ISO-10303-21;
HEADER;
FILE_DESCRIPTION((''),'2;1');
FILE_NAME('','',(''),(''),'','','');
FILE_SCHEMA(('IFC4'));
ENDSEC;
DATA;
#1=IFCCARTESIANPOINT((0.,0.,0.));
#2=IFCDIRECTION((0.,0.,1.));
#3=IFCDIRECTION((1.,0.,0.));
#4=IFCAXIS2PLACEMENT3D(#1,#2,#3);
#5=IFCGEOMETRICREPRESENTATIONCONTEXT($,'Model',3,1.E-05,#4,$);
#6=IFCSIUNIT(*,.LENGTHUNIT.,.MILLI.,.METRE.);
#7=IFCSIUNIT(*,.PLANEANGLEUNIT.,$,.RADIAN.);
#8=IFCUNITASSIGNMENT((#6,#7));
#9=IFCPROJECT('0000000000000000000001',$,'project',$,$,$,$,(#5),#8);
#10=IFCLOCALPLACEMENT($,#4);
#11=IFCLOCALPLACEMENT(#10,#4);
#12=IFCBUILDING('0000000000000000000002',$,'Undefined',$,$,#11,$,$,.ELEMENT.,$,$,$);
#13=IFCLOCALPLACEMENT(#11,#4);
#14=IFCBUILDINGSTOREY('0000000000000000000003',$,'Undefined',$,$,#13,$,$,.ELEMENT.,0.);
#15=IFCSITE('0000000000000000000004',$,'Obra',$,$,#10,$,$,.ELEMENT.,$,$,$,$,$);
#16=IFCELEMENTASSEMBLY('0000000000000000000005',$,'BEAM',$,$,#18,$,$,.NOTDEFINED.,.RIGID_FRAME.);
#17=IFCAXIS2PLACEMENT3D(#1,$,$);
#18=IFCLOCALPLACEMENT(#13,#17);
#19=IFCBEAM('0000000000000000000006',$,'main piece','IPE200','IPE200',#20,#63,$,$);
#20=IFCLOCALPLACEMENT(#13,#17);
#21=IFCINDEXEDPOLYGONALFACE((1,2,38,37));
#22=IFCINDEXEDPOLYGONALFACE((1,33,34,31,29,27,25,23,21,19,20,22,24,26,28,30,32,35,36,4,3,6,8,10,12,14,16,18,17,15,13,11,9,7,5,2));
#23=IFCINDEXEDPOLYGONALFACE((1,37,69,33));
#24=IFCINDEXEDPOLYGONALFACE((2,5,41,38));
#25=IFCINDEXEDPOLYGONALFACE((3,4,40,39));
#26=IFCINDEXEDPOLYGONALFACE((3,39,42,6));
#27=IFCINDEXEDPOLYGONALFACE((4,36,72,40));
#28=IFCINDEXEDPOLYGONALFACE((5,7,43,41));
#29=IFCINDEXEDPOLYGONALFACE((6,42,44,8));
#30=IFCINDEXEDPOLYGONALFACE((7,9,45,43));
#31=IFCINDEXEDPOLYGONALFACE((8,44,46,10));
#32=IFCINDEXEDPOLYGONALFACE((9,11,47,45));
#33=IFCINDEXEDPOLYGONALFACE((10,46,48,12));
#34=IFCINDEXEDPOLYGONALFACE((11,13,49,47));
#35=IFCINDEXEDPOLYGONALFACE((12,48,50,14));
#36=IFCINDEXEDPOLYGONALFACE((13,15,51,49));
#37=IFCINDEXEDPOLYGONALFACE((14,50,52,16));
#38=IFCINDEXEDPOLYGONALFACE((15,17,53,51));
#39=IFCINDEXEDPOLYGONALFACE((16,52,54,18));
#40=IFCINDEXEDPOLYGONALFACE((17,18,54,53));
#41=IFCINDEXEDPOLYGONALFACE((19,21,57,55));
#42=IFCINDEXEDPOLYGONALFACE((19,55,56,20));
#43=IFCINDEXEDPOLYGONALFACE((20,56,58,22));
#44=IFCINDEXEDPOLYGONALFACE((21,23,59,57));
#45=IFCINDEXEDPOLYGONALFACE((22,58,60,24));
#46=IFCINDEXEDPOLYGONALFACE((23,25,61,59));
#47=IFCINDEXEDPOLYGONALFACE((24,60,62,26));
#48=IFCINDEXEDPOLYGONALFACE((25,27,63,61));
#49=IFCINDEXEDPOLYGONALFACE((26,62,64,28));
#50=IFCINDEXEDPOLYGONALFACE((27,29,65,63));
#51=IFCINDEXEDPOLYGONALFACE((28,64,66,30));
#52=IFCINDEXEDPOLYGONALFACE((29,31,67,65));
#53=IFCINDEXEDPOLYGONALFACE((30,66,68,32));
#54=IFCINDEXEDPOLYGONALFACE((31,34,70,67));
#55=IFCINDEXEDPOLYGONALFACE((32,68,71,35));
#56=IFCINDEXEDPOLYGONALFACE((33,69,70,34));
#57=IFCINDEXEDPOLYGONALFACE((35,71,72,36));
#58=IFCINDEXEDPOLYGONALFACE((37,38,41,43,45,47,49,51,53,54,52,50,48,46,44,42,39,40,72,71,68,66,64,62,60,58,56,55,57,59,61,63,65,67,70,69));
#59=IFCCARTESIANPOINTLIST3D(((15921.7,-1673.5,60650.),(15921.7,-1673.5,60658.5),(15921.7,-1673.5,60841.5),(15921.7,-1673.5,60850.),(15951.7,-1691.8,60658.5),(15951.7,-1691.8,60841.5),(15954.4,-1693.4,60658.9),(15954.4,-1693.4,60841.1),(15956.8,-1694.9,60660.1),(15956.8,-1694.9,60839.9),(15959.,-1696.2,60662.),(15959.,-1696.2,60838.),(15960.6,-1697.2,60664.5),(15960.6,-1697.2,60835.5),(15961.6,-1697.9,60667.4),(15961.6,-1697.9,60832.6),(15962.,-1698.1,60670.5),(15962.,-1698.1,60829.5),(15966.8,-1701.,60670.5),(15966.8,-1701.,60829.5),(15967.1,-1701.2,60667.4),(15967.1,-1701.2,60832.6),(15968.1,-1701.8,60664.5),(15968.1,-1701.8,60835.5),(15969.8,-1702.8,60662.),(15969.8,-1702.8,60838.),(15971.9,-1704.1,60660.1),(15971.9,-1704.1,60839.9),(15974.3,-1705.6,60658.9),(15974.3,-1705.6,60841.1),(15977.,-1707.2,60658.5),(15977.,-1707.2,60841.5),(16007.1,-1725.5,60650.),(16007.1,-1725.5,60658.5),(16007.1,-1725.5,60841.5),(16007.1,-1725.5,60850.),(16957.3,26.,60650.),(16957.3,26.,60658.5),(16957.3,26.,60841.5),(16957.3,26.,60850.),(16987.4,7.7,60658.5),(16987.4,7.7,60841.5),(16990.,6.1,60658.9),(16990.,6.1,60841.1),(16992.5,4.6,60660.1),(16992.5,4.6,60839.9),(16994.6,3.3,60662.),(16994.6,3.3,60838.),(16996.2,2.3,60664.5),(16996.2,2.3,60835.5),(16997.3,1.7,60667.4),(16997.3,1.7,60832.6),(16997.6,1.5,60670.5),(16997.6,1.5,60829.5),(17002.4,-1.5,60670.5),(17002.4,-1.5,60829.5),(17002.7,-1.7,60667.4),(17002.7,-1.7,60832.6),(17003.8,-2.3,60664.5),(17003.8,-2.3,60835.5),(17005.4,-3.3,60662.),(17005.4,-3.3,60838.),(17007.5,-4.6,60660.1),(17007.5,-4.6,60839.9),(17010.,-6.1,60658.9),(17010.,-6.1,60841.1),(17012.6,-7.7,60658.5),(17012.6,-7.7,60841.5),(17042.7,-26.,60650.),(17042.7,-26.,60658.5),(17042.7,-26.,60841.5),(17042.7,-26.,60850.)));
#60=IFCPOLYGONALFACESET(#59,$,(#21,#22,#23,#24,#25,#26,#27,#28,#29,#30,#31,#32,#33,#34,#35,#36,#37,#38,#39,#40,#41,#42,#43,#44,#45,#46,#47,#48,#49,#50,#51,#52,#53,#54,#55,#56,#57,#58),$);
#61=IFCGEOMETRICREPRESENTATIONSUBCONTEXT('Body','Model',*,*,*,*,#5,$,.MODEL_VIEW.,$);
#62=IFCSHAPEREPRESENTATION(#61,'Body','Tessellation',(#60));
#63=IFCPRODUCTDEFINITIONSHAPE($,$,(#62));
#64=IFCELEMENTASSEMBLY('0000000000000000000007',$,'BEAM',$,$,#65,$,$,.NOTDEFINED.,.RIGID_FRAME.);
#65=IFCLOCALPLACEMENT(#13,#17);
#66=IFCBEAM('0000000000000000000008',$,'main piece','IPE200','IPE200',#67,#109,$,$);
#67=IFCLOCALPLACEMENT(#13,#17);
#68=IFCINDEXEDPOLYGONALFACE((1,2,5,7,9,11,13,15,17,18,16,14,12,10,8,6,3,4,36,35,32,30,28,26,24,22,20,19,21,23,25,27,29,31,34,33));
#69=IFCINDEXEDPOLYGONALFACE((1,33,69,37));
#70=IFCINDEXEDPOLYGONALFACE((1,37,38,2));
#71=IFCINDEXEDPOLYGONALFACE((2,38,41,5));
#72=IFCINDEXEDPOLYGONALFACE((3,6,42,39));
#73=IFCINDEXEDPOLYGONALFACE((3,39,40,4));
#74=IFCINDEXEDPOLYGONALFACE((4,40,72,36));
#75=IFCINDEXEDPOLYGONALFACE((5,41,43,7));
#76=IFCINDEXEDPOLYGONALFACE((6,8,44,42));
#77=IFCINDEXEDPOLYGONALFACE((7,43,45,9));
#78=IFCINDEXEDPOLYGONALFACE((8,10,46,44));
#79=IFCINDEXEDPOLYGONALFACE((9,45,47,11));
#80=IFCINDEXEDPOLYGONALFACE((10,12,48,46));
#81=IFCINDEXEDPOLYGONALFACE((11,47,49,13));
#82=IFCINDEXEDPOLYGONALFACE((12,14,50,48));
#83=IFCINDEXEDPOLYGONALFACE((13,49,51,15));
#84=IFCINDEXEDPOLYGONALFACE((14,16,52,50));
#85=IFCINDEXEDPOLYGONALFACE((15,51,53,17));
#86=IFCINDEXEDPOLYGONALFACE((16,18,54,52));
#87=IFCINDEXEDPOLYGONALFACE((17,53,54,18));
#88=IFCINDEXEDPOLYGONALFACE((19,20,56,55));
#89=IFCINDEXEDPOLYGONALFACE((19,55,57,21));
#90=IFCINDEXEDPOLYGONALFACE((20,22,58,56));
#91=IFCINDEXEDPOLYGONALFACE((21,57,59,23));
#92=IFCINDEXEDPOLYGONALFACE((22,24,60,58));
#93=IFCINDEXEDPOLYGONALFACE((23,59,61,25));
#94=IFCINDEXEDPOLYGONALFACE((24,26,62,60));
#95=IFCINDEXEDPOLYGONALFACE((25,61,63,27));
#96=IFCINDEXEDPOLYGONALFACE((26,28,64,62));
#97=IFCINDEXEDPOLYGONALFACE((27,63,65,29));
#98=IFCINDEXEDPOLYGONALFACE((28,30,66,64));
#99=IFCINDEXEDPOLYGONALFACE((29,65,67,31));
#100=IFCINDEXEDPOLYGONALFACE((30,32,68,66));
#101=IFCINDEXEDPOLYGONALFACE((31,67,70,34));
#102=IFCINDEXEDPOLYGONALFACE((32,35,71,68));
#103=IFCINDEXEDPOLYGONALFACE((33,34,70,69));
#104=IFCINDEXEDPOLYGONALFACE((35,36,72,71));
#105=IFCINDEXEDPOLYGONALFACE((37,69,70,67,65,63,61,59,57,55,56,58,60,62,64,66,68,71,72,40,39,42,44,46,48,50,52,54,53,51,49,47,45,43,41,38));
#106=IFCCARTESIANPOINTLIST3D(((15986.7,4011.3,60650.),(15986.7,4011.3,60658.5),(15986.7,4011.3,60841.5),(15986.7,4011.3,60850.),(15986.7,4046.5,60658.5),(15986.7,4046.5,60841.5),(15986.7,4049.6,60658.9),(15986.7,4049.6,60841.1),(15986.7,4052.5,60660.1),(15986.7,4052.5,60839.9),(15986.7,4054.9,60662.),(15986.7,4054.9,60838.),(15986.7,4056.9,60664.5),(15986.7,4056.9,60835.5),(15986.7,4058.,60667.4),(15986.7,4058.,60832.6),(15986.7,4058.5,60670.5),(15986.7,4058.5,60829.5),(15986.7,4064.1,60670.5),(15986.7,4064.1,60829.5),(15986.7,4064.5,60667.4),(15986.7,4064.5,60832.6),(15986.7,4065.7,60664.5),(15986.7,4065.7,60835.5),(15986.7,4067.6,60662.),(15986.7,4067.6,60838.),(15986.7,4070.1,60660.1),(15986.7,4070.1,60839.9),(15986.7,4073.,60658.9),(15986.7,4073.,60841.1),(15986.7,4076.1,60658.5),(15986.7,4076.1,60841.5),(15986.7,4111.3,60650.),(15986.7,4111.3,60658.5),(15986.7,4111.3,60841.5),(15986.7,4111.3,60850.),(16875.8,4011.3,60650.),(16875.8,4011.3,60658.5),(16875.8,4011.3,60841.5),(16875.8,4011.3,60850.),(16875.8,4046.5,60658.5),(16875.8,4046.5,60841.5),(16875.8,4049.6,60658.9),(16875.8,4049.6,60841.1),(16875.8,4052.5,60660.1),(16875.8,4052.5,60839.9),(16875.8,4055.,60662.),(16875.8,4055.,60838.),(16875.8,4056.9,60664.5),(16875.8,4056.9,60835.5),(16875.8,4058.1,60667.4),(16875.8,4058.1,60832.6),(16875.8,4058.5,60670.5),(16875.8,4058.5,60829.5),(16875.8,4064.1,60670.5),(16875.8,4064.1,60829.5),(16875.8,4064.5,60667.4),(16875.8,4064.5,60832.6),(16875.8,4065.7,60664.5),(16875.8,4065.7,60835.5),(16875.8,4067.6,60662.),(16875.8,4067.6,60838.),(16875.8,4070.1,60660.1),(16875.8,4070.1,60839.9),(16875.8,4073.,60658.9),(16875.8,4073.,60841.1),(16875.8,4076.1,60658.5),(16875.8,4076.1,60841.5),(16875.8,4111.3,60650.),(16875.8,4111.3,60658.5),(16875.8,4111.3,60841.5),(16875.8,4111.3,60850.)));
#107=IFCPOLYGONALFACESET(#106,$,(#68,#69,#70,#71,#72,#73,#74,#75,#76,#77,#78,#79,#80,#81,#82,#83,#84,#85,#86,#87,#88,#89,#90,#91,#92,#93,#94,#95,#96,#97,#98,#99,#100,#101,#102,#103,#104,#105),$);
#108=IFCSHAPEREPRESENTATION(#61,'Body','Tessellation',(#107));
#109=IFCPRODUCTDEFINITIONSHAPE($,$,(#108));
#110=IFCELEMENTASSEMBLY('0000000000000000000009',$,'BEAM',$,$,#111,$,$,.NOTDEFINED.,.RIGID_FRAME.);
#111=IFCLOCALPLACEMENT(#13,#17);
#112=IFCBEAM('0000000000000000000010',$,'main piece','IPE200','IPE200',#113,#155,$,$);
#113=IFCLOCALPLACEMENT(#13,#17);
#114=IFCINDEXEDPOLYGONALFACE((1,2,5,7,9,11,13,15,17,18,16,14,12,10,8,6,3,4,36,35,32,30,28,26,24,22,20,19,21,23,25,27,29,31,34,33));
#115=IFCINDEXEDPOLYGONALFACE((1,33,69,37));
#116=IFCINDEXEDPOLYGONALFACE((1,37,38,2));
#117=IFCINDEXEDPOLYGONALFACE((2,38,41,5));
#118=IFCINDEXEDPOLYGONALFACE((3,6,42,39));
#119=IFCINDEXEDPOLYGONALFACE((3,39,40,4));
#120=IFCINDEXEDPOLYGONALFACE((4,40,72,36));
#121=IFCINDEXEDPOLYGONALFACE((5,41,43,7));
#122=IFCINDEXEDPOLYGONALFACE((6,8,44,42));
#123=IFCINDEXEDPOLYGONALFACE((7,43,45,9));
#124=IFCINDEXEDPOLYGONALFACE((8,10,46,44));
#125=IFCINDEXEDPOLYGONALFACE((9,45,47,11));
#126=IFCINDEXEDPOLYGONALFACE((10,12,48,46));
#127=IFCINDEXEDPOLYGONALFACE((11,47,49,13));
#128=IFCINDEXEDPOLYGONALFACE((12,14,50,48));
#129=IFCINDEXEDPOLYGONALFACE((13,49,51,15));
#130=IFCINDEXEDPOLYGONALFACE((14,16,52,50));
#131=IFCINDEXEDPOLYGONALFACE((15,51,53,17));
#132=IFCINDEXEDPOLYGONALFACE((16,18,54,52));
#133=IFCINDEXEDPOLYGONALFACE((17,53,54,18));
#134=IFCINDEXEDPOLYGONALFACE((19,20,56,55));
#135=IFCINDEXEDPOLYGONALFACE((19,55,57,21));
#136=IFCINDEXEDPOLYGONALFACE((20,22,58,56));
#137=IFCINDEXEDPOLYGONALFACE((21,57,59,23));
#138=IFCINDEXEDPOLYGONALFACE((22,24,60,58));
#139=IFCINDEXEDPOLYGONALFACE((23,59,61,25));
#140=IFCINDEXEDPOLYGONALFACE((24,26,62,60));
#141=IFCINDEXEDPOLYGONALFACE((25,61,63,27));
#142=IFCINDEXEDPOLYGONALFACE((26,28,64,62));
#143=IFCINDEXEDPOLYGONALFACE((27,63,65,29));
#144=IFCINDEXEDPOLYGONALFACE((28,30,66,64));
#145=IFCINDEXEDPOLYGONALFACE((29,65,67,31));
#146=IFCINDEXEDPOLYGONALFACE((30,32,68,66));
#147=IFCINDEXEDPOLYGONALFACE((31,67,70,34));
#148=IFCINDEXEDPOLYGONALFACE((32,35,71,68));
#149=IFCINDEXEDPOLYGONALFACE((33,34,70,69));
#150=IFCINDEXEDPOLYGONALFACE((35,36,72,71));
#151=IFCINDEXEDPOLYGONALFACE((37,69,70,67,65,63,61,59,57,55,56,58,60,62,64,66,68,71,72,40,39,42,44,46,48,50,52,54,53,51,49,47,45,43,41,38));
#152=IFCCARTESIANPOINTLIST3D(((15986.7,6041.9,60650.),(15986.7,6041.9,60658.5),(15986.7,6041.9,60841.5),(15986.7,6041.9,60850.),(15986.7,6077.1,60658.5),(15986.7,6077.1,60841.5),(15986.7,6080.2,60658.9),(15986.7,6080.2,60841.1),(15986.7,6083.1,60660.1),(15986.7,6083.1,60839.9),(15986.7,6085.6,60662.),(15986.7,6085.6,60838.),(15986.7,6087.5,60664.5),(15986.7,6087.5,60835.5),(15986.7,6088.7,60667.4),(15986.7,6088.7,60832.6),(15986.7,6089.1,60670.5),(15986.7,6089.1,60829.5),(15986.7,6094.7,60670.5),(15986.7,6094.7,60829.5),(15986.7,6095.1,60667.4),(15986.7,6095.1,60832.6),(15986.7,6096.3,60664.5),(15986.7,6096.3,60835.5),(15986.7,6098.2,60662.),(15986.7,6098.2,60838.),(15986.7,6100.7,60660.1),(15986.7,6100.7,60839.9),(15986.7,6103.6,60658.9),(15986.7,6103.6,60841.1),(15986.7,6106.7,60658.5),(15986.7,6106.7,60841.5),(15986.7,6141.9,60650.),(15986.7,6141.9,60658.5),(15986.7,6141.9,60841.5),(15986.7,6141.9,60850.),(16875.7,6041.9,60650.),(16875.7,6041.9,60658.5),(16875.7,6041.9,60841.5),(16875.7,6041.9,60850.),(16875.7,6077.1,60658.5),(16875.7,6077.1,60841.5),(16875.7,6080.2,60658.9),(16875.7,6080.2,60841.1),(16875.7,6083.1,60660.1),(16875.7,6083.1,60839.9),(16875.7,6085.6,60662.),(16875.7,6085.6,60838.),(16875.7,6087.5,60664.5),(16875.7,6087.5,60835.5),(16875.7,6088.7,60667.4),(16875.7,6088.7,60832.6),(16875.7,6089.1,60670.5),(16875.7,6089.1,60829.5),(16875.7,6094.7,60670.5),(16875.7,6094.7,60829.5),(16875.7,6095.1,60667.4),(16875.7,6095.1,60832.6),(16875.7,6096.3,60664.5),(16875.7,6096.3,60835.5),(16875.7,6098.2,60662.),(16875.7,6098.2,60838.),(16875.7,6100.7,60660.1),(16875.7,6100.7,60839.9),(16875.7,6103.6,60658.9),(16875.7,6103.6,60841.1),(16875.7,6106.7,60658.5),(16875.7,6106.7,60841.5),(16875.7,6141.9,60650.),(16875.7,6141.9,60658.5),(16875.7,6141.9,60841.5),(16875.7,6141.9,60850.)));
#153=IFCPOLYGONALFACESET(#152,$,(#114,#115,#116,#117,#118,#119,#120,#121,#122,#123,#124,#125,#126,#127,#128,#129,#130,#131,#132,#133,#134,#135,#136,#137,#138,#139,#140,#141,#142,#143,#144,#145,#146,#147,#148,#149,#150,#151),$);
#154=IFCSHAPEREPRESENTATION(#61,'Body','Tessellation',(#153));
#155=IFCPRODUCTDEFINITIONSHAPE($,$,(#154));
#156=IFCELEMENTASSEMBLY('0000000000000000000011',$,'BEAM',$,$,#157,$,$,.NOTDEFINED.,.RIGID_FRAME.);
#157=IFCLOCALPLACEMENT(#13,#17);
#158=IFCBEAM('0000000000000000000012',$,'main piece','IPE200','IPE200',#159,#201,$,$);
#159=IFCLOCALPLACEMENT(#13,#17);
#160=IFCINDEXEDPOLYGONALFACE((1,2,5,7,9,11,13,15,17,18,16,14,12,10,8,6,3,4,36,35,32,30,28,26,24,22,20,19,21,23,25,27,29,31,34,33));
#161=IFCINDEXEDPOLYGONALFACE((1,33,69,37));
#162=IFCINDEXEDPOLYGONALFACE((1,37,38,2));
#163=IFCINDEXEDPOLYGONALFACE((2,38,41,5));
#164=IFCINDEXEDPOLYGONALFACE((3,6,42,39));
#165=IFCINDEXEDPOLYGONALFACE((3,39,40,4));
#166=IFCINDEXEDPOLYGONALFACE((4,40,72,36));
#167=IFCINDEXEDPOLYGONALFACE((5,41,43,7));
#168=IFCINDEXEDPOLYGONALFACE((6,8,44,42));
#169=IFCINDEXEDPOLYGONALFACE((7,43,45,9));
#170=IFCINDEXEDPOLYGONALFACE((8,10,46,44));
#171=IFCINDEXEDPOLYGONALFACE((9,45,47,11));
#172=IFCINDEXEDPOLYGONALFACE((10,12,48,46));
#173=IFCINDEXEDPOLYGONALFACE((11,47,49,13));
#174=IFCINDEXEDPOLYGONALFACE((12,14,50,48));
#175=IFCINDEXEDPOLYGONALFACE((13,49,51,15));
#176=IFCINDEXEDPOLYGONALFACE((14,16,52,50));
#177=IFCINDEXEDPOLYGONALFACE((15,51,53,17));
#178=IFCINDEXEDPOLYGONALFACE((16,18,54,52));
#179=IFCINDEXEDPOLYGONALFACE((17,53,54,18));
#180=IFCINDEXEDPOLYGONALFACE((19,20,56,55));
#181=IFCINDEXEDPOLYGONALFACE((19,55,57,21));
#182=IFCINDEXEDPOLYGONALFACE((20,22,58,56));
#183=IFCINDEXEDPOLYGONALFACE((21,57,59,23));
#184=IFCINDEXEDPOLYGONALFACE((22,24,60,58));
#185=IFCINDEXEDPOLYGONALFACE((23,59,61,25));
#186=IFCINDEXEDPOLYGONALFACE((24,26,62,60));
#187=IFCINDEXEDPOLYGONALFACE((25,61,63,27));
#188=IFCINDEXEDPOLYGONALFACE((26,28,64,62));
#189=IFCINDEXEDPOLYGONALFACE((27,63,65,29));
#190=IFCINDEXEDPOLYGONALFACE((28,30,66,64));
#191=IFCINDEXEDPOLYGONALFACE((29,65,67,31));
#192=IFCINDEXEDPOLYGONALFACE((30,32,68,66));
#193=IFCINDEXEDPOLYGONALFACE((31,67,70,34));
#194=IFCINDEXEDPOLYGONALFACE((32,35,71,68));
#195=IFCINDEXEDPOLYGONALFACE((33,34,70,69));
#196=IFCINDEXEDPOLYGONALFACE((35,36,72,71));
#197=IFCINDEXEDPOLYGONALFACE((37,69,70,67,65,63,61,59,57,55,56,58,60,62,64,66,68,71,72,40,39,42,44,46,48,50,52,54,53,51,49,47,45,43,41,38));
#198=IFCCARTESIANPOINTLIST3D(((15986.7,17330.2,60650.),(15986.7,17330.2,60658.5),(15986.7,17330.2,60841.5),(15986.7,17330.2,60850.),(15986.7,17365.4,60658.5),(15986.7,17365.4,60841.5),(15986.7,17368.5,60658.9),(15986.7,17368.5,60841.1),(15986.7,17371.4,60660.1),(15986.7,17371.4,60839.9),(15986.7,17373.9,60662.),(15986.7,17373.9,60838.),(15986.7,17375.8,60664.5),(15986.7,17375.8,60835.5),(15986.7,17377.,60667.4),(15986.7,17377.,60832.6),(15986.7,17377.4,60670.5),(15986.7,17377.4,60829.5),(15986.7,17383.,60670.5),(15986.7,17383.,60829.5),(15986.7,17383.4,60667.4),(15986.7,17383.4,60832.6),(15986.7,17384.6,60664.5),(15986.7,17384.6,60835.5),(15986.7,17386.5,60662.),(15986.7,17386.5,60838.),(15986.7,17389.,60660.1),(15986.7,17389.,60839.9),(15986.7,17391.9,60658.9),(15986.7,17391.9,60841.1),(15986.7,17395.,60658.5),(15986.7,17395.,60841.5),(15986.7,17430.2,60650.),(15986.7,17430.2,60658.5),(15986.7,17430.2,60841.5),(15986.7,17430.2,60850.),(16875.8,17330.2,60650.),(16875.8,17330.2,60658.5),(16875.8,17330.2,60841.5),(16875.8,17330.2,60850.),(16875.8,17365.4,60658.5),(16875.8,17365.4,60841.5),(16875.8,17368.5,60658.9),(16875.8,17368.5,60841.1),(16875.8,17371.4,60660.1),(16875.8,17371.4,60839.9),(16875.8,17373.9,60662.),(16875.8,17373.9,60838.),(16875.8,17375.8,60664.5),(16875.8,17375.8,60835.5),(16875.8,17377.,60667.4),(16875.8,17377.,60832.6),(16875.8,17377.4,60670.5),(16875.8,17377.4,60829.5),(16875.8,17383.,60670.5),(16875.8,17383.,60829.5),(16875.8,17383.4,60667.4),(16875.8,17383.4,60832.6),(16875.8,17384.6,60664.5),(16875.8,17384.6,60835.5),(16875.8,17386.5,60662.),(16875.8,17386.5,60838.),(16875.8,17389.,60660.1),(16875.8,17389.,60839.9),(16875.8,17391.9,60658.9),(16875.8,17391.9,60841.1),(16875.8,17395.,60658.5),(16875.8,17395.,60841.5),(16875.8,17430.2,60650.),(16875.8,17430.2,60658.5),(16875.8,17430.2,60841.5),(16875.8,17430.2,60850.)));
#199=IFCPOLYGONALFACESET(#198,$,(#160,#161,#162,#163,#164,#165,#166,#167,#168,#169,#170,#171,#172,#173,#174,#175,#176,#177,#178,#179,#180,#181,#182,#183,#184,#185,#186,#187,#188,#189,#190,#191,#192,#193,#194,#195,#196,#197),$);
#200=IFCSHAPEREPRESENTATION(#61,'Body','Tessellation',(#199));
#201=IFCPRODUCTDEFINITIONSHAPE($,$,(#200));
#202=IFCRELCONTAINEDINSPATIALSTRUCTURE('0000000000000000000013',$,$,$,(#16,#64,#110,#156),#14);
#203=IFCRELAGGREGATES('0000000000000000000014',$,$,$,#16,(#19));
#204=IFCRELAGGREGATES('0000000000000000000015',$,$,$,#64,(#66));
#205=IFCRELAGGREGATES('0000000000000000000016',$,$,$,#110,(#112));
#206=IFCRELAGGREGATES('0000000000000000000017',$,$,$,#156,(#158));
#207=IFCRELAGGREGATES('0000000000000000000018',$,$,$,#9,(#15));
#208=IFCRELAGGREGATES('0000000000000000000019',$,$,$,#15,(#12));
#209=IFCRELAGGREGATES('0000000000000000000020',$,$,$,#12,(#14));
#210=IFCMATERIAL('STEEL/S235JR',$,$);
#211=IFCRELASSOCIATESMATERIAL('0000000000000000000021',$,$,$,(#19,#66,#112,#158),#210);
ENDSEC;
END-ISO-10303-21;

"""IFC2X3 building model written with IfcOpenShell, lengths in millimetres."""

from ifc_helpers import new_model, si_unit, frame, origin_with_axes, origin_2d_with_axis, place, context, subcontext, project, spatial, i_section, extrude, material, element, aggregate, save


model = new_model("IFC2X3")

# Units and contexts
model_context = context("Model", 3, precision=1e-05, world=origin_with_axes())
body_context = subcontext(model_context, "Body", "Model", "MODEL_VIEW")
ifc_project = project(units=[si_unit("LENGTHUNIT", "METRE", prefix="MILLI"), si_unit("PLANEANGLEUNIT", "RADIAN")], contexts=[model_context])

# Site, building, storey
site_placement = place(None, origin_with_axes())
site = spatial("IfcSite", under=ifc_project, at=site_placement, Name="Obra", CompositionType="ELEMENT")
building_placement = place(site_placement, origin_with_axes())
building = spatial("IfcBuilding", under=site, at=building_placement, Name="Undefined", CompositionType="ELEMENT")
storey_placement = place(building_placement, origin_with_axes())
storey = spatial("IfcBuildingStorey", under=building, at=storey_placement, Name="Undefined", CompositionType="ELEMENT", Elevation=0.0)

# Element assemblies, beams
ifc_material_1 = material(Name="STEEL/S235JR")
assembly_1_placement = place(storey_placement, origin_with_axes())
assembly_1 = element("IfcElementAssembly", 1, at=assembly_1_placement, inside=storey, Name="BEAM", AssemblyPlace="NOTDEFINED", PredefinedType="RIGID_FRAME")
beam_1_placement = place(assembly_1_placement, frame((17000.0, 0.0, 60750.0), z_axis=(0.0, 0.0, 1.0), x_axis=(-0.520368, -0.853942, 0.0)))
beam_1 = element("IfcBeam", 2, at=beam_1_placement, material=ifc_material_1, Name="main piece", Description="IPE200", ObjectType="IPE200", context=body_context, shape_type="SweptSolid", body=[
    extrude(i_section(OverallWidth=100.0, OverallDepth=200.0, WebThickness=5.6, FlangeThickness=8.5, FilletRadius=12.0, at=origin_2d_with_axis()), frame((1990.2, 0.0, 0.0), z_axis=(-1.0, 0.0, 0.0), x_axis=(0.0, -1.0, 0.0)), (0.0, 0.0, 1.0), 1990.2),
])
aggregate(assembly_1, [beam_1])
assembly_2_placement = place(storey_placement, origin_with_axes())
assembly_2 = element("IfcElementAssembly", 3, at=assembly_2_placement, inside=storey, Name="BEAM", AssemblyPlace="NOTDEFINED", PredefinedType="RIGID_FRAME")
beam_2_placement = place(assembly_2_placement, frame((16875.8, 4061.3, 60750.0), z_axis=(0.0, 0.0, 1.0), x_axis=(-1.0, -0.000044, 0.0)))
beam_2 = element("IfcBeam", 4, at=beam_2_placement, material=ifc_material_1, Name="main piece", Description="IPE200", ObjectType="IPE200", context=body_context, shape_type="SweptSolid", body=[
    extrude(i_section(OverallWidth=100.0, OverallDepth=200.0, WebThickness=5.6, FlangeThickness=8.5, FilletRadius=12.0, at=origin_2d_with_axis()), frame((889.1, 0.0, 0.0), z_axis=(-1.0, 0.0, 0.0), x_axis=(0.0, -1.0, 0.0)), (0.0, 0.0, 1.0), 889.1),
])
aggregate(assembly_2, [beam_2])
assembly_3_placement = place(storey_placement, origin_with_axes())
assembly_3 = element("IfcElementAssembly", 5, at=assembly_3_placement, inside=storey, Name="BEAM", AssemblyPlace="NOTDEFINED", PredefinedType="RIGID_FRAME")
beam_3_placement = place(assembly_3_placement, frame((16875.7, 6091.9, 60750.0), z_axis=(0.0, 0.0, 1.0), x_axis=(-1.0, 0.0, 0.0)))
beam_3 = element("IfcBeam", 6, at=beam_3_placement, material=ifc_material_1, Name="main piece", Description="IPE200", ObjectType="IPE200", context=body_context, shape_type="SweptSolid", body=[
    extrude(i_section(OverallWidth=100.0, OverallDepth=200.0, WebThickness=5.6, FlangeThickness=8.5, FilletRadius=12.0, at=origin_2d_with_axis()), frame((889.0, 0.0, 0.0), z_axis=(-1.0, 0.0, 0.0), x_axis=(0.0, -1.0, 0.0)), (0.0, 0.0, 1.0), 889.0),
])
aggregate(assembly_3, [beam_3])
assembly_4_placement = place(storey_placement, origin_with_axes())
assembly_4 = element("IfcElementAssembly", 7, at=assembly_4_placement, inside=storey, Name="BEAM", AssemblyPlace="NOTDEFINED", PredefinedType="RIGID_FRAME")
beam_4_placement = place(assembly_4_placement, frame((16875.8, 17380.2, 60750.0), z_axis=(0.0, 0.0, 1.0), x_axis=(-1.0, 0.0, 0.0)))
beam_4 = element("IfcBeam", 8, at=beam_4_placement, material=ifc_material_1, Name="main piece", Description="IPE200", ObjectType="IPE200", context=body_context, shape_type="SweptSolid", body=[
    extrude(i_section(OverallWidth=100.0, OverallDepth=200.0, WebThickness=5.6, FlangeThickness=8.5, FilletRadius=12.0, at=origin_2d_with_axis()), frame((889.1, 0.0, 0.0), z_axis=(-1.0, 0.0, 0.0), x_axis=(0.0, -1.0, 0.0)), (0.0, 0.0, 1.0), 889.1),
])
aggregate(assembly_4, [beam_4])

save(model, "model.ifc")
